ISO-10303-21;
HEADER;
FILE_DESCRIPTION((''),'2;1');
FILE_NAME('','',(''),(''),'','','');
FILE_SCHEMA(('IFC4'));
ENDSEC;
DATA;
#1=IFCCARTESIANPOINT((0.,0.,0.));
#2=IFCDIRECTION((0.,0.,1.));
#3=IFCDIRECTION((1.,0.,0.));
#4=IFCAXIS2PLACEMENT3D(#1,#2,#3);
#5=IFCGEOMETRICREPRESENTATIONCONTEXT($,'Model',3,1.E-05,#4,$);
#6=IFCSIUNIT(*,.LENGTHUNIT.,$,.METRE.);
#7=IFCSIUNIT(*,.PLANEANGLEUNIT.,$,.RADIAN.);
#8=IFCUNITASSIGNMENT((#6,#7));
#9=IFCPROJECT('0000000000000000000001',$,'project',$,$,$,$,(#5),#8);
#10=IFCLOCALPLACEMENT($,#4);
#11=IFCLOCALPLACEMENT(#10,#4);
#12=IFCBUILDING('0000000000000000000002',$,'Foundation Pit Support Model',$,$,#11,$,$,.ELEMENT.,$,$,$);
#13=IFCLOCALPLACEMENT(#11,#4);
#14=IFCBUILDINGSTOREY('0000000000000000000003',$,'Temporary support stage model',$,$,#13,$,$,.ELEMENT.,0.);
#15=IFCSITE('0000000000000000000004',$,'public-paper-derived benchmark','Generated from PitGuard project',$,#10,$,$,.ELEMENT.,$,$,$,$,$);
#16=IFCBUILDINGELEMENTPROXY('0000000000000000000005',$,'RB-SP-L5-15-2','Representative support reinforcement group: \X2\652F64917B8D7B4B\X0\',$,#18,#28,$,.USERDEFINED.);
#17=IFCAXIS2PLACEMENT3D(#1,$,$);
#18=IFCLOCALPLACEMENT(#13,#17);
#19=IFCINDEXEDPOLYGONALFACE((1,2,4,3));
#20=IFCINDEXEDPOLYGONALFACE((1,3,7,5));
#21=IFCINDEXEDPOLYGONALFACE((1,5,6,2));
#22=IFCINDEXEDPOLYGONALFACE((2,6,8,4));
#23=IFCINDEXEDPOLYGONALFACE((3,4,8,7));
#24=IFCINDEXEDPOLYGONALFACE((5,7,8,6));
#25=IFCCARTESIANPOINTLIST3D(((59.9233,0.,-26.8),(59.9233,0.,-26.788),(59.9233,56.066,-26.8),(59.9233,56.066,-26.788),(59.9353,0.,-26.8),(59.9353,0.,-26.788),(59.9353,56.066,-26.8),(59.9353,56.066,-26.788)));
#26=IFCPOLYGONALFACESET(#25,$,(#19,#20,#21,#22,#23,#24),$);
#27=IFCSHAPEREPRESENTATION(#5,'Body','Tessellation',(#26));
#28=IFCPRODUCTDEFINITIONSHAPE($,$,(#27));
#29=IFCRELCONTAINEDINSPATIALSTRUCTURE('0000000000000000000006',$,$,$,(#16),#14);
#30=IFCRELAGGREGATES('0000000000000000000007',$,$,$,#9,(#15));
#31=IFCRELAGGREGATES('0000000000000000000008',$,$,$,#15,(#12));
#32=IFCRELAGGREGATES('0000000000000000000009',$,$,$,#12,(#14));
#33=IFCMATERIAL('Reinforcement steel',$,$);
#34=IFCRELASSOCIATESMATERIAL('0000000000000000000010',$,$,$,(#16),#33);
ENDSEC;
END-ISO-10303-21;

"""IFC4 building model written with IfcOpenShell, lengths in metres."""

from ifc_helpers import new_model, si_unit, frame, origin_with_axes, origin_2d, place, context, project, spatial, rectangle, extrude, material, element, save


model = new_model("IFC4")

# Units and contexts
model_context = context("Model", 3, precision=1e-05, world=origin_with_axes())
ifc_project = project(units=[si_unit("LENGTHUNIT", "METRE"), si_unit("PLANEANGLEUNIT", "RADIAN")], contexts=[model_context])

# Site, building, storey
site_placement = place(None, origin_with_axes())
site = spatial("IfcSite", under=ifc_project, at=site_placement, Name="public-paper-derived benchmark", Description="Generated from PitGuard project", CompositionType="ELEMENT")
building_placement = place(site_placement, origin_with_axes())
building = spatial("IfcBuilding", under=site, at=building_placement, Name="Foundation Pit Support Model", CompositionType="ELEMENT")
storey_placement = place(building_placement, origin_with_axes())
storey = spatial("IfcBuildingStorey", under=building, at=storey_placement, Name="Temporary support stage model", CompositionType="ELEMENT", Elevation=0.0)

# Building element proxy
ifc_material_1 = material(Name="Reinforcement steel")
proxy_1_placement = place(storey_placement, frame((59.9293, 28.033, -26.8), z_axis=(0.0, 0.0, 1.0), x_axis=(0.0, 1.0, 0.0)))
element("IfcBuildingElementProxy", 1, at=proxy_1_placement, inside=storey, material=ifc_material_1, Name="RB-SP-L5-15-2", Description="Representative support reinforcement group: 支撑箍筋", PredefinedType="USERDEFINED", context=model_context, shape_type="SweptSolid", body=[
    extrude(rectangle(XDim=56.066, YDim=0.012, at=origin_2d()), origin_with_axes(), (0.0, 0.0, 1.0), 0.012),
])

save(model, "model.ifc")
